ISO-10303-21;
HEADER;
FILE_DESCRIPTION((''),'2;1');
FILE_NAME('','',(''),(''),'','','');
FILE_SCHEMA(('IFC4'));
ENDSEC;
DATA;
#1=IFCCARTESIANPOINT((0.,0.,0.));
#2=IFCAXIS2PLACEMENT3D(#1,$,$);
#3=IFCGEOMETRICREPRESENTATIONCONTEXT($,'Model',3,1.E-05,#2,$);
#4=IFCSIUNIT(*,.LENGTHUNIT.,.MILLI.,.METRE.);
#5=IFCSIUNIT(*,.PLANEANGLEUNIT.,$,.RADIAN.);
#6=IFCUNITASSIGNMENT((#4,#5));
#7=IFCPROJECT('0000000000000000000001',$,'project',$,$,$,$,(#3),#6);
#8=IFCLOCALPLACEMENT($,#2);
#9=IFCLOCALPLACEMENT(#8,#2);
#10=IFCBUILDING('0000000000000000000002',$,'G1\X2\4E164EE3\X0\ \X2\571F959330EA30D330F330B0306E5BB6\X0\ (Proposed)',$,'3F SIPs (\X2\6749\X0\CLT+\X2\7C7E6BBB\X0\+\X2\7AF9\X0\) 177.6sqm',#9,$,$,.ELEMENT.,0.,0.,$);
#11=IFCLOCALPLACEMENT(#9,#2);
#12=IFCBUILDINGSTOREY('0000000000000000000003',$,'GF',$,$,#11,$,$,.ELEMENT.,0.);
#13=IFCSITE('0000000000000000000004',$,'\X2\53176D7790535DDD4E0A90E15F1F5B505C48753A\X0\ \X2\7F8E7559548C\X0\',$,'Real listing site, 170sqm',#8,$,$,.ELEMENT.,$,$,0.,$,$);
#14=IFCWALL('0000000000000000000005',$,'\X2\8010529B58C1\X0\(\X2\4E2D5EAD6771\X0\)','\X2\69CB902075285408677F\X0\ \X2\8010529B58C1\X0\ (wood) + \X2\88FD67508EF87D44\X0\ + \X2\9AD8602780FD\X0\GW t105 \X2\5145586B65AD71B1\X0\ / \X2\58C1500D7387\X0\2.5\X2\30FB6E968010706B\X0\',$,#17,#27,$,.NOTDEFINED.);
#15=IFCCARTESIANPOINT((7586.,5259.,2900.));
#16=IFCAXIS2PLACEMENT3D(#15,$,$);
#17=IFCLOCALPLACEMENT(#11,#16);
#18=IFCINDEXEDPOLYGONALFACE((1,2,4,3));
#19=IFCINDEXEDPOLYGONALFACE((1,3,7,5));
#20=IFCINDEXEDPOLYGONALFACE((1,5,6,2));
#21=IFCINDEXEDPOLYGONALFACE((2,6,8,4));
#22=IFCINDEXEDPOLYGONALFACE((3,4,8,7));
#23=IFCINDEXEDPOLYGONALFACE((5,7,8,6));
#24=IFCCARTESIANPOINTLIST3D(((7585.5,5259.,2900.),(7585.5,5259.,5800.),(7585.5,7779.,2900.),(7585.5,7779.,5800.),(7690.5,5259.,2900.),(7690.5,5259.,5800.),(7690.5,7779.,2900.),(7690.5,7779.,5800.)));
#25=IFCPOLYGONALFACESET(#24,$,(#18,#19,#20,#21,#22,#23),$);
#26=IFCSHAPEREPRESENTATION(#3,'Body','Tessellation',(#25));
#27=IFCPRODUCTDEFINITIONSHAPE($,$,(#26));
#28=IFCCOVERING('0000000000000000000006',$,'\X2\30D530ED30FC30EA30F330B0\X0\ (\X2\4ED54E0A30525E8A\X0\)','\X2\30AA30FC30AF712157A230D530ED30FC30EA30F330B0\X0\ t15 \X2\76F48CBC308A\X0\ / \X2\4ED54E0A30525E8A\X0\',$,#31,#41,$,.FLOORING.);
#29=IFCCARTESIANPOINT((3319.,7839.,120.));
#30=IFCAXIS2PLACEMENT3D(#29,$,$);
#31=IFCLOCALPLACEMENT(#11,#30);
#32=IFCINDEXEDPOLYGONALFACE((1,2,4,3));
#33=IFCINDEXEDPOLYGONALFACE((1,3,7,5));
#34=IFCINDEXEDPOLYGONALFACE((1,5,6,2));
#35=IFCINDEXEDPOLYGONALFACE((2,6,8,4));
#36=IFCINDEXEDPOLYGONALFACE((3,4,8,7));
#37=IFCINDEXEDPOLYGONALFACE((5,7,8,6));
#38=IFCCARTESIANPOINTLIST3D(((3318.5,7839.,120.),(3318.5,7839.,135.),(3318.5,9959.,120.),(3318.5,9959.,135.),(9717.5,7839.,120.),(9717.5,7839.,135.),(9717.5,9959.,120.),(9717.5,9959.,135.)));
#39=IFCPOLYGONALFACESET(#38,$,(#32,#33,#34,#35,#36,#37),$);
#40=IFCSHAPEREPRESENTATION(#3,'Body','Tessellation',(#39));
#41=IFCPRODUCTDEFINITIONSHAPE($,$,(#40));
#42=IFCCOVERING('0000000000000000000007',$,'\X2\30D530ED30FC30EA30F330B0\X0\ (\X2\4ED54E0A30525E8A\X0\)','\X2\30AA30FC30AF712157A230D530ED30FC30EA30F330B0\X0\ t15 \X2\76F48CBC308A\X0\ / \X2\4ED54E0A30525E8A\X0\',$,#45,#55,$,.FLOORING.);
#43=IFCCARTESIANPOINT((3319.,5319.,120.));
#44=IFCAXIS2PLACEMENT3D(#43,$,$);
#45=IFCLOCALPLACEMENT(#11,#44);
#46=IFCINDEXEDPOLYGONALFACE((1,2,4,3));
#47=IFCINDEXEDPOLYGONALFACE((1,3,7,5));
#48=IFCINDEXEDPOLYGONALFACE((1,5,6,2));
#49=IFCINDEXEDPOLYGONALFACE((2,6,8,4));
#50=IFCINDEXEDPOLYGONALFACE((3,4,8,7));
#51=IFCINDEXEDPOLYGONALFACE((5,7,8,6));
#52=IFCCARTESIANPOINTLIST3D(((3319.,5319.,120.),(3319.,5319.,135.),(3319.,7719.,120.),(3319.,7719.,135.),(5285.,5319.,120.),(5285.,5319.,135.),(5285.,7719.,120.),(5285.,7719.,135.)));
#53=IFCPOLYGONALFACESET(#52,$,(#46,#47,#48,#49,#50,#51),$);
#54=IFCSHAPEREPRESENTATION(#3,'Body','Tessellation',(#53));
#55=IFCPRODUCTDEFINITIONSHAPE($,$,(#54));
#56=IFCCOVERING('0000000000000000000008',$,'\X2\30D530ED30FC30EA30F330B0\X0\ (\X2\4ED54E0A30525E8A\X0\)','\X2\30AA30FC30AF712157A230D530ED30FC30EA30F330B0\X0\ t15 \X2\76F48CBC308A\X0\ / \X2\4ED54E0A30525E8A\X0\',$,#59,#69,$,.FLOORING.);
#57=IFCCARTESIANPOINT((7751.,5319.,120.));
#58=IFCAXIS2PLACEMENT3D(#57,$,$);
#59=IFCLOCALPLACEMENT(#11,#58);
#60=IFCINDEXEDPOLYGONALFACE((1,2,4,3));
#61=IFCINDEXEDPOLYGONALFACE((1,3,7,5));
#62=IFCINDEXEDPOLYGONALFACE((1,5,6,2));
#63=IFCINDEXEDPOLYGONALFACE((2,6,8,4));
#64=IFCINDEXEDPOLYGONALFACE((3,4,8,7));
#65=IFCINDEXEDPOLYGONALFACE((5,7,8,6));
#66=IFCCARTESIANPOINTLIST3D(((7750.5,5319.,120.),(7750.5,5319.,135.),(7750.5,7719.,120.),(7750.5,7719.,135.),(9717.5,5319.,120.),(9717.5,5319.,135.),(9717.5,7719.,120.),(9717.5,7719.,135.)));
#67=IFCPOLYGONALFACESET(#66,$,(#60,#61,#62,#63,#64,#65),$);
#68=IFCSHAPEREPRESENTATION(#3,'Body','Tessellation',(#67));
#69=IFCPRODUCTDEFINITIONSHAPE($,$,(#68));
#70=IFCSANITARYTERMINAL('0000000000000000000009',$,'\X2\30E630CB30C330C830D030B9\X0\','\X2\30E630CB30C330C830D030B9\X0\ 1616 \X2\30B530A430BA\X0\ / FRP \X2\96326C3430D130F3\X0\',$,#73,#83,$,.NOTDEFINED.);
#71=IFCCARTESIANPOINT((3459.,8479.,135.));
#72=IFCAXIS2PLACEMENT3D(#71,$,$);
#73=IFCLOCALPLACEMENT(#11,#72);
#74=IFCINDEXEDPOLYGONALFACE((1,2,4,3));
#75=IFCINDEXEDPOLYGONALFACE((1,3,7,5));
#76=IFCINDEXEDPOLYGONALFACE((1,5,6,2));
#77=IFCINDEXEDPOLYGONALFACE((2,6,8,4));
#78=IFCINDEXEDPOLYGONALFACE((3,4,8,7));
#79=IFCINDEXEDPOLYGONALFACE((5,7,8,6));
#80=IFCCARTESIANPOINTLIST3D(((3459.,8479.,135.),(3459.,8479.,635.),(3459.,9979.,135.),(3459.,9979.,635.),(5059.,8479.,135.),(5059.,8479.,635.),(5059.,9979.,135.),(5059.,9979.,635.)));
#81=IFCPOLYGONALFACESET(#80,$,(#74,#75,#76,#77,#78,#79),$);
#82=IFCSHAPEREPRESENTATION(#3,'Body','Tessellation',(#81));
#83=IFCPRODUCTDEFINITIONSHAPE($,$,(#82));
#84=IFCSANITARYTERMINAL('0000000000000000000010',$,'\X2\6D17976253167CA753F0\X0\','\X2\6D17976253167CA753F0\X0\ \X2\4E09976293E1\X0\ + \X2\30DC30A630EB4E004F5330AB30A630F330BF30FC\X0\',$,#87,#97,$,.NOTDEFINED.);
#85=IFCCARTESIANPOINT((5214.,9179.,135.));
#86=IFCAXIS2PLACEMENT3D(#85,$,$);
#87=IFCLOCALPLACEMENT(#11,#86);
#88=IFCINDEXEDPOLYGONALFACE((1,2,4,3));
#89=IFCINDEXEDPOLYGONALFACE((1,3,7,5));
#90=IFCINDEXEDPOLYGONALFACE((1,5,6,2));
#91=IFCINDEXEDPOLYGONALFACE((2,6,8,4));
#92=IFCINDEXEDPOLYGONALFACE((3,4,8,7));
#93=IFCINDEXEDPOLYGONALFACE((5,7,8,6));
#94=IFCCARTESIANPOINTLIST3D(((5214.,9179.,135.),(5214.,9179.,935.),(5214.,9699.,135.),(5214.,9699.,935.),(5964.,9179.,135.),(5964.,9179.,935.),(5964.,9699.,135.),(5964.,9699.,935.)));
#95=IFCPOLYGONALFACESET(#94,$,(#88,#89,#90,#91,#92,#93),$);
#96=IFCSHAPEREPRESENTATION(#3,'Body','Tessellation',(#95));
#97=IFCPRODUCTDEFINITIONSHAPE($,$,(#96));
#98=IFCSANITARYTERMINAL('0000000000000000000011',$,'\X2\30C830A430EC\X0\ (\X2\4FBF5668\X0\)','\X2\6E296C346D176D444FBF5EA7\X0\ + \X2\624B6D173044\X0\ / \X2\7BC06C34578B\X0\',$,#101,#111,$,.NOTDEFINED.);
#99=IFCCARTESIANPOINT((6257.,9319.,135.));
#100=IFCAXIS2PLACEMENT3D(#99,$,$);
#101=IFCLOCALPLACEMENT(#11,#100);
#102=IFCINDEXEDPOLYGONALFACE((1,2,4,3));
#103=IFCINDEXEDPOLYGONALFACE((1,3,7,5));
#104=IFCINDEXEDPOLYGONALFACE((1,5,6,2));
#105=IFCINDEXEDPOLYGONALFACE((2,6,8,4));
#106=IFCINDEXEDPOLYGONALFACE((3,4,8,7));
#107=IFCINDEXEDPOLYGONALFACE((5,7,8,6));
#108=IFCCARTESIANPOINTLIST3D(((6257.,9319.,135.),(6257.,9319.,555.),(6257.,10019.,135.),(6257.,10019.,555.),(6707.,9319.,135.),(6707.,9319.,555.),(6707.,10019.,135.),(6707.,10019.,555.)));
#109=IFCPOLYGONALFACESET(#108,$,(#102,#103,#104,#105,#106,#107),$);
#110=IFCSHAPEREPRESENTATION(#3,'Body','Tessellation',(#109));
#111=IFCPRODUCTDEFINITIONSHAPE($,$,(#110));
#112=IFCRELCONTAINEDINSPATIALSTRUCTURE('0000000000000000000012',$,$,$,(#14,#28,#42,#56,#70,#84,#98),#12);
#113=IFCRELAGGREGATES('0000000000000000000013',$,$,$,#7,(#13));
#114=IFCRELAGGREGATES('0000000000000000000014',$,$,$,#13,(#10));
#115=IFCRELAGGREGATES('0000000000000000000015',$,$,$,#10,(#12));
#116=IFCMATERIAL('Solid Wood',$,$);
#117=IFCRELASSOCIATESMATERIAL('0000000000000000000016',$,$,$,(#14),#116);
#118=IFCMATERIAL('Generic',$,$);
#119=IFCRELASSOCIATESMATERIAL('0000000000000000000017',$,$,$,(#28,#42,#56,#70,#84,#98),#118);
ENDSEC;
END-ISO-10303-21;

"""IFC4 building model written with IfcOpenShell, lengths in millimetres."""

from ifc_helpers import new_model, si_unit, frame, frame_2d, origin, place, context, project, spatial, rectangle, extrude, material, element, save


model = new_model("IFC4")

# Units and contexts
model_context = context("Model", 3, precision=1e-05, world=origin())
ifc_project = project(units=[si_unit("LENGTHUNIT", "METRE", prefix="MILLI"), si_unit("PLANEANGLEUNIT", "RADIAN")], contexts=[model_context])

# Site, building, storey
site_placement = place(None, origin())
site = spatial("IfcSite", under=ifc_project, at=site_placement, Name="北海道川上郡弟子屈町 美留和", ObjectType="Real listing site, 170sqm", CompositionType="ELEMENT", RefElevation=0.0)
building_placement = place(site_placement, origin())
building = spatial("IfcBuilding", under=site, at=building_placement, Name="G1世代 土間リビングの家 (Proposed)", ObjectType="3F SIPs (杉CLT+籾殻+竹) 177.6sqm", CompositionType="ELEMENT", ElevationOfRefHeight=0.0, ElevationOfTerrain=0.0)
storey_placement = place(building_placement, origin())
storey = spatial("IfcBuildingStorey", under=building, at=storey_placement, Name="GF", CompositionType="ELEMENT", Elevation=0.0)

# Shared definitions
ifc_material_1 = material(Name="Solid Wood")

# Wall
wall_1_placement = place(storey_placement, frame((7586.0, 5259.0, 2900.0)))
element("IfcWall", 1, at=wall_1_placement, inside=storey, material=ifc_material_1, Name="耐力壁(中庭東)", Description="構造用合板 耐力壁 (wood) + 製材軸組 + 高性能GW t105 充填断熱 / 壁倍率2.5・準耐火", PredefinedType="NOTDEFINED", context=model_context, shape_type="SweptSolid", body=[
    extrude(rectangle(XDim=105.0, YDim=2520.0, at=frame_2d((52.0, 1260.0))), frame((7586.0, 5259.0, 2900.0)), (0.0, 0.0, 1.0), 2900.0),
])

# Coverings
ifc_material_2 = material(Name="Generic")
covering_1_placement = place(storey_placement, frame((3319.0, 7839.0, 120.0)))
element("IfcCovering", 2, at=covering_1_placement, inside=storey, material=ifc_material_2, Name="フローリング (仕上げ床)", Description="オーク無垢フローリング t15 直貼り / 仕上げ床", PredefinedType="FLOORING", context=model_context, shape_type="SweptSolid", body=[
    extrude(rectangle(XDim=6399.0, YDim=2120.0, at=frame_2d((3199.0, 1060.0))), frame((3319.0, 7839.0, 120.0)), (0.0, 0.0, 1.0), 15.0),
])
covering_2_placement = place(storey_placement, frame((3319.0, 5319.0, 120.0)))
element("IfcCovering", 3, at=covering_2_placement, inside=storey, material=ifc_material_2, Name="フローリング (仕上げ床)", Description="オーク無垢フローリング t15 直貼り / 仕上げ床", PredefinedType="FLOORING", context=model_context, shape_type="SweptSolid", body=[
    extrude(rectangle(XDim=1966.0, YDim=2400.0, at=frame_2d((983.0, 1200.0))), frame((3319.0, 5319.0, 120.0)), (0.0, 0.0, 1.0), 15.0),
])
covering_3_placement = place(storey_placement, frame((7751.0, 5319.0, 120.0)))
element("IfcCovering", 4, at=covering_3_placement, inside=storey, material=ifc_material_2, Name="フローリング (仕上げ床)", Description="オーク無垢フローリング t15 直貼り / 仕上げ床", PredefinedType="FLOORING", context=model_context, shape_type="SweptSolid", body=[
    extrude(rectangle(XDim=1967.0, YDim=2400.0, at=frame_2d((983.0, 1200.0))), frame((7751.0, 5319.0, 120.0)), (0.0, 0.0, 1.0), 15.0),
])

# Sanitary terminals
sanitary_terminal_1_placement = place(storey_placement, frame((3459.0, 8479.0, 135.0)))
element("IfcSanitaryTerminal", 5, at=sanitary_terminal_1_placement, inside=storey, material=ifc_material_2, Name="ユニットバス", Description="ユニットバス 1616 サイズ / FRP 防水パン", PredefinedType="NOTDEFINED", context=model_context, shape_type="SweptSolid", body=[
    extrude(rectangle(XDim=1600.0, YDim=1500.0, at=frame_2d((800.0, 750.0))), frame((3459.0, 8479.0, 135.0)), (0.0, 0.0, 1.0), 500.0),
])
sanitary_terminal_2_placement = place(storey_placement, frame((5214.0, 9179.0, 135.0)))
element("IfcSanitaryTerminal", 6, at=sanitary_terminal_2_placement, inside=storey, material=ifc_material_2, Name="洗面化粧台", Description="洗面化粧台 三面鏡 + ボウル一体カウンター", PredefinedType="NOTDEFINED", context=model_context, shape_type="SweptSolid", body=[
    extrude(rectangle(XDim=750.0, YDim=520.0, at=frame_2d((375.0, 260.0))), frame((5214.0, 9179.0, 135.0)), (0.0, 0.0, 1.0), 800.0),
])
sanitary_terminal_3_placement = place(storey_placement, frame((6257.0, 9319.0, 135.0)))
element("IfcSanitaryTerminal", 7, at=sanitary_terminal_3_placement, inside=storey, material=ifc_material_2, Name="トイレ (便器)", Description="温水洗浄便座 + 手洗い / 節水型", PredefinedType="NOTDEFINED", context=model_context, shape_type="SweptSolid", body=[
    extrude(rectangle(XDim=450.0, YDim=700.0, at=frame_2d((225.0, 350.0))), frame((6257.0, 9319.0, 135.0)), (0.0, 0.0, 1.0), 420.0),
])

save(model, "model.ifc")
